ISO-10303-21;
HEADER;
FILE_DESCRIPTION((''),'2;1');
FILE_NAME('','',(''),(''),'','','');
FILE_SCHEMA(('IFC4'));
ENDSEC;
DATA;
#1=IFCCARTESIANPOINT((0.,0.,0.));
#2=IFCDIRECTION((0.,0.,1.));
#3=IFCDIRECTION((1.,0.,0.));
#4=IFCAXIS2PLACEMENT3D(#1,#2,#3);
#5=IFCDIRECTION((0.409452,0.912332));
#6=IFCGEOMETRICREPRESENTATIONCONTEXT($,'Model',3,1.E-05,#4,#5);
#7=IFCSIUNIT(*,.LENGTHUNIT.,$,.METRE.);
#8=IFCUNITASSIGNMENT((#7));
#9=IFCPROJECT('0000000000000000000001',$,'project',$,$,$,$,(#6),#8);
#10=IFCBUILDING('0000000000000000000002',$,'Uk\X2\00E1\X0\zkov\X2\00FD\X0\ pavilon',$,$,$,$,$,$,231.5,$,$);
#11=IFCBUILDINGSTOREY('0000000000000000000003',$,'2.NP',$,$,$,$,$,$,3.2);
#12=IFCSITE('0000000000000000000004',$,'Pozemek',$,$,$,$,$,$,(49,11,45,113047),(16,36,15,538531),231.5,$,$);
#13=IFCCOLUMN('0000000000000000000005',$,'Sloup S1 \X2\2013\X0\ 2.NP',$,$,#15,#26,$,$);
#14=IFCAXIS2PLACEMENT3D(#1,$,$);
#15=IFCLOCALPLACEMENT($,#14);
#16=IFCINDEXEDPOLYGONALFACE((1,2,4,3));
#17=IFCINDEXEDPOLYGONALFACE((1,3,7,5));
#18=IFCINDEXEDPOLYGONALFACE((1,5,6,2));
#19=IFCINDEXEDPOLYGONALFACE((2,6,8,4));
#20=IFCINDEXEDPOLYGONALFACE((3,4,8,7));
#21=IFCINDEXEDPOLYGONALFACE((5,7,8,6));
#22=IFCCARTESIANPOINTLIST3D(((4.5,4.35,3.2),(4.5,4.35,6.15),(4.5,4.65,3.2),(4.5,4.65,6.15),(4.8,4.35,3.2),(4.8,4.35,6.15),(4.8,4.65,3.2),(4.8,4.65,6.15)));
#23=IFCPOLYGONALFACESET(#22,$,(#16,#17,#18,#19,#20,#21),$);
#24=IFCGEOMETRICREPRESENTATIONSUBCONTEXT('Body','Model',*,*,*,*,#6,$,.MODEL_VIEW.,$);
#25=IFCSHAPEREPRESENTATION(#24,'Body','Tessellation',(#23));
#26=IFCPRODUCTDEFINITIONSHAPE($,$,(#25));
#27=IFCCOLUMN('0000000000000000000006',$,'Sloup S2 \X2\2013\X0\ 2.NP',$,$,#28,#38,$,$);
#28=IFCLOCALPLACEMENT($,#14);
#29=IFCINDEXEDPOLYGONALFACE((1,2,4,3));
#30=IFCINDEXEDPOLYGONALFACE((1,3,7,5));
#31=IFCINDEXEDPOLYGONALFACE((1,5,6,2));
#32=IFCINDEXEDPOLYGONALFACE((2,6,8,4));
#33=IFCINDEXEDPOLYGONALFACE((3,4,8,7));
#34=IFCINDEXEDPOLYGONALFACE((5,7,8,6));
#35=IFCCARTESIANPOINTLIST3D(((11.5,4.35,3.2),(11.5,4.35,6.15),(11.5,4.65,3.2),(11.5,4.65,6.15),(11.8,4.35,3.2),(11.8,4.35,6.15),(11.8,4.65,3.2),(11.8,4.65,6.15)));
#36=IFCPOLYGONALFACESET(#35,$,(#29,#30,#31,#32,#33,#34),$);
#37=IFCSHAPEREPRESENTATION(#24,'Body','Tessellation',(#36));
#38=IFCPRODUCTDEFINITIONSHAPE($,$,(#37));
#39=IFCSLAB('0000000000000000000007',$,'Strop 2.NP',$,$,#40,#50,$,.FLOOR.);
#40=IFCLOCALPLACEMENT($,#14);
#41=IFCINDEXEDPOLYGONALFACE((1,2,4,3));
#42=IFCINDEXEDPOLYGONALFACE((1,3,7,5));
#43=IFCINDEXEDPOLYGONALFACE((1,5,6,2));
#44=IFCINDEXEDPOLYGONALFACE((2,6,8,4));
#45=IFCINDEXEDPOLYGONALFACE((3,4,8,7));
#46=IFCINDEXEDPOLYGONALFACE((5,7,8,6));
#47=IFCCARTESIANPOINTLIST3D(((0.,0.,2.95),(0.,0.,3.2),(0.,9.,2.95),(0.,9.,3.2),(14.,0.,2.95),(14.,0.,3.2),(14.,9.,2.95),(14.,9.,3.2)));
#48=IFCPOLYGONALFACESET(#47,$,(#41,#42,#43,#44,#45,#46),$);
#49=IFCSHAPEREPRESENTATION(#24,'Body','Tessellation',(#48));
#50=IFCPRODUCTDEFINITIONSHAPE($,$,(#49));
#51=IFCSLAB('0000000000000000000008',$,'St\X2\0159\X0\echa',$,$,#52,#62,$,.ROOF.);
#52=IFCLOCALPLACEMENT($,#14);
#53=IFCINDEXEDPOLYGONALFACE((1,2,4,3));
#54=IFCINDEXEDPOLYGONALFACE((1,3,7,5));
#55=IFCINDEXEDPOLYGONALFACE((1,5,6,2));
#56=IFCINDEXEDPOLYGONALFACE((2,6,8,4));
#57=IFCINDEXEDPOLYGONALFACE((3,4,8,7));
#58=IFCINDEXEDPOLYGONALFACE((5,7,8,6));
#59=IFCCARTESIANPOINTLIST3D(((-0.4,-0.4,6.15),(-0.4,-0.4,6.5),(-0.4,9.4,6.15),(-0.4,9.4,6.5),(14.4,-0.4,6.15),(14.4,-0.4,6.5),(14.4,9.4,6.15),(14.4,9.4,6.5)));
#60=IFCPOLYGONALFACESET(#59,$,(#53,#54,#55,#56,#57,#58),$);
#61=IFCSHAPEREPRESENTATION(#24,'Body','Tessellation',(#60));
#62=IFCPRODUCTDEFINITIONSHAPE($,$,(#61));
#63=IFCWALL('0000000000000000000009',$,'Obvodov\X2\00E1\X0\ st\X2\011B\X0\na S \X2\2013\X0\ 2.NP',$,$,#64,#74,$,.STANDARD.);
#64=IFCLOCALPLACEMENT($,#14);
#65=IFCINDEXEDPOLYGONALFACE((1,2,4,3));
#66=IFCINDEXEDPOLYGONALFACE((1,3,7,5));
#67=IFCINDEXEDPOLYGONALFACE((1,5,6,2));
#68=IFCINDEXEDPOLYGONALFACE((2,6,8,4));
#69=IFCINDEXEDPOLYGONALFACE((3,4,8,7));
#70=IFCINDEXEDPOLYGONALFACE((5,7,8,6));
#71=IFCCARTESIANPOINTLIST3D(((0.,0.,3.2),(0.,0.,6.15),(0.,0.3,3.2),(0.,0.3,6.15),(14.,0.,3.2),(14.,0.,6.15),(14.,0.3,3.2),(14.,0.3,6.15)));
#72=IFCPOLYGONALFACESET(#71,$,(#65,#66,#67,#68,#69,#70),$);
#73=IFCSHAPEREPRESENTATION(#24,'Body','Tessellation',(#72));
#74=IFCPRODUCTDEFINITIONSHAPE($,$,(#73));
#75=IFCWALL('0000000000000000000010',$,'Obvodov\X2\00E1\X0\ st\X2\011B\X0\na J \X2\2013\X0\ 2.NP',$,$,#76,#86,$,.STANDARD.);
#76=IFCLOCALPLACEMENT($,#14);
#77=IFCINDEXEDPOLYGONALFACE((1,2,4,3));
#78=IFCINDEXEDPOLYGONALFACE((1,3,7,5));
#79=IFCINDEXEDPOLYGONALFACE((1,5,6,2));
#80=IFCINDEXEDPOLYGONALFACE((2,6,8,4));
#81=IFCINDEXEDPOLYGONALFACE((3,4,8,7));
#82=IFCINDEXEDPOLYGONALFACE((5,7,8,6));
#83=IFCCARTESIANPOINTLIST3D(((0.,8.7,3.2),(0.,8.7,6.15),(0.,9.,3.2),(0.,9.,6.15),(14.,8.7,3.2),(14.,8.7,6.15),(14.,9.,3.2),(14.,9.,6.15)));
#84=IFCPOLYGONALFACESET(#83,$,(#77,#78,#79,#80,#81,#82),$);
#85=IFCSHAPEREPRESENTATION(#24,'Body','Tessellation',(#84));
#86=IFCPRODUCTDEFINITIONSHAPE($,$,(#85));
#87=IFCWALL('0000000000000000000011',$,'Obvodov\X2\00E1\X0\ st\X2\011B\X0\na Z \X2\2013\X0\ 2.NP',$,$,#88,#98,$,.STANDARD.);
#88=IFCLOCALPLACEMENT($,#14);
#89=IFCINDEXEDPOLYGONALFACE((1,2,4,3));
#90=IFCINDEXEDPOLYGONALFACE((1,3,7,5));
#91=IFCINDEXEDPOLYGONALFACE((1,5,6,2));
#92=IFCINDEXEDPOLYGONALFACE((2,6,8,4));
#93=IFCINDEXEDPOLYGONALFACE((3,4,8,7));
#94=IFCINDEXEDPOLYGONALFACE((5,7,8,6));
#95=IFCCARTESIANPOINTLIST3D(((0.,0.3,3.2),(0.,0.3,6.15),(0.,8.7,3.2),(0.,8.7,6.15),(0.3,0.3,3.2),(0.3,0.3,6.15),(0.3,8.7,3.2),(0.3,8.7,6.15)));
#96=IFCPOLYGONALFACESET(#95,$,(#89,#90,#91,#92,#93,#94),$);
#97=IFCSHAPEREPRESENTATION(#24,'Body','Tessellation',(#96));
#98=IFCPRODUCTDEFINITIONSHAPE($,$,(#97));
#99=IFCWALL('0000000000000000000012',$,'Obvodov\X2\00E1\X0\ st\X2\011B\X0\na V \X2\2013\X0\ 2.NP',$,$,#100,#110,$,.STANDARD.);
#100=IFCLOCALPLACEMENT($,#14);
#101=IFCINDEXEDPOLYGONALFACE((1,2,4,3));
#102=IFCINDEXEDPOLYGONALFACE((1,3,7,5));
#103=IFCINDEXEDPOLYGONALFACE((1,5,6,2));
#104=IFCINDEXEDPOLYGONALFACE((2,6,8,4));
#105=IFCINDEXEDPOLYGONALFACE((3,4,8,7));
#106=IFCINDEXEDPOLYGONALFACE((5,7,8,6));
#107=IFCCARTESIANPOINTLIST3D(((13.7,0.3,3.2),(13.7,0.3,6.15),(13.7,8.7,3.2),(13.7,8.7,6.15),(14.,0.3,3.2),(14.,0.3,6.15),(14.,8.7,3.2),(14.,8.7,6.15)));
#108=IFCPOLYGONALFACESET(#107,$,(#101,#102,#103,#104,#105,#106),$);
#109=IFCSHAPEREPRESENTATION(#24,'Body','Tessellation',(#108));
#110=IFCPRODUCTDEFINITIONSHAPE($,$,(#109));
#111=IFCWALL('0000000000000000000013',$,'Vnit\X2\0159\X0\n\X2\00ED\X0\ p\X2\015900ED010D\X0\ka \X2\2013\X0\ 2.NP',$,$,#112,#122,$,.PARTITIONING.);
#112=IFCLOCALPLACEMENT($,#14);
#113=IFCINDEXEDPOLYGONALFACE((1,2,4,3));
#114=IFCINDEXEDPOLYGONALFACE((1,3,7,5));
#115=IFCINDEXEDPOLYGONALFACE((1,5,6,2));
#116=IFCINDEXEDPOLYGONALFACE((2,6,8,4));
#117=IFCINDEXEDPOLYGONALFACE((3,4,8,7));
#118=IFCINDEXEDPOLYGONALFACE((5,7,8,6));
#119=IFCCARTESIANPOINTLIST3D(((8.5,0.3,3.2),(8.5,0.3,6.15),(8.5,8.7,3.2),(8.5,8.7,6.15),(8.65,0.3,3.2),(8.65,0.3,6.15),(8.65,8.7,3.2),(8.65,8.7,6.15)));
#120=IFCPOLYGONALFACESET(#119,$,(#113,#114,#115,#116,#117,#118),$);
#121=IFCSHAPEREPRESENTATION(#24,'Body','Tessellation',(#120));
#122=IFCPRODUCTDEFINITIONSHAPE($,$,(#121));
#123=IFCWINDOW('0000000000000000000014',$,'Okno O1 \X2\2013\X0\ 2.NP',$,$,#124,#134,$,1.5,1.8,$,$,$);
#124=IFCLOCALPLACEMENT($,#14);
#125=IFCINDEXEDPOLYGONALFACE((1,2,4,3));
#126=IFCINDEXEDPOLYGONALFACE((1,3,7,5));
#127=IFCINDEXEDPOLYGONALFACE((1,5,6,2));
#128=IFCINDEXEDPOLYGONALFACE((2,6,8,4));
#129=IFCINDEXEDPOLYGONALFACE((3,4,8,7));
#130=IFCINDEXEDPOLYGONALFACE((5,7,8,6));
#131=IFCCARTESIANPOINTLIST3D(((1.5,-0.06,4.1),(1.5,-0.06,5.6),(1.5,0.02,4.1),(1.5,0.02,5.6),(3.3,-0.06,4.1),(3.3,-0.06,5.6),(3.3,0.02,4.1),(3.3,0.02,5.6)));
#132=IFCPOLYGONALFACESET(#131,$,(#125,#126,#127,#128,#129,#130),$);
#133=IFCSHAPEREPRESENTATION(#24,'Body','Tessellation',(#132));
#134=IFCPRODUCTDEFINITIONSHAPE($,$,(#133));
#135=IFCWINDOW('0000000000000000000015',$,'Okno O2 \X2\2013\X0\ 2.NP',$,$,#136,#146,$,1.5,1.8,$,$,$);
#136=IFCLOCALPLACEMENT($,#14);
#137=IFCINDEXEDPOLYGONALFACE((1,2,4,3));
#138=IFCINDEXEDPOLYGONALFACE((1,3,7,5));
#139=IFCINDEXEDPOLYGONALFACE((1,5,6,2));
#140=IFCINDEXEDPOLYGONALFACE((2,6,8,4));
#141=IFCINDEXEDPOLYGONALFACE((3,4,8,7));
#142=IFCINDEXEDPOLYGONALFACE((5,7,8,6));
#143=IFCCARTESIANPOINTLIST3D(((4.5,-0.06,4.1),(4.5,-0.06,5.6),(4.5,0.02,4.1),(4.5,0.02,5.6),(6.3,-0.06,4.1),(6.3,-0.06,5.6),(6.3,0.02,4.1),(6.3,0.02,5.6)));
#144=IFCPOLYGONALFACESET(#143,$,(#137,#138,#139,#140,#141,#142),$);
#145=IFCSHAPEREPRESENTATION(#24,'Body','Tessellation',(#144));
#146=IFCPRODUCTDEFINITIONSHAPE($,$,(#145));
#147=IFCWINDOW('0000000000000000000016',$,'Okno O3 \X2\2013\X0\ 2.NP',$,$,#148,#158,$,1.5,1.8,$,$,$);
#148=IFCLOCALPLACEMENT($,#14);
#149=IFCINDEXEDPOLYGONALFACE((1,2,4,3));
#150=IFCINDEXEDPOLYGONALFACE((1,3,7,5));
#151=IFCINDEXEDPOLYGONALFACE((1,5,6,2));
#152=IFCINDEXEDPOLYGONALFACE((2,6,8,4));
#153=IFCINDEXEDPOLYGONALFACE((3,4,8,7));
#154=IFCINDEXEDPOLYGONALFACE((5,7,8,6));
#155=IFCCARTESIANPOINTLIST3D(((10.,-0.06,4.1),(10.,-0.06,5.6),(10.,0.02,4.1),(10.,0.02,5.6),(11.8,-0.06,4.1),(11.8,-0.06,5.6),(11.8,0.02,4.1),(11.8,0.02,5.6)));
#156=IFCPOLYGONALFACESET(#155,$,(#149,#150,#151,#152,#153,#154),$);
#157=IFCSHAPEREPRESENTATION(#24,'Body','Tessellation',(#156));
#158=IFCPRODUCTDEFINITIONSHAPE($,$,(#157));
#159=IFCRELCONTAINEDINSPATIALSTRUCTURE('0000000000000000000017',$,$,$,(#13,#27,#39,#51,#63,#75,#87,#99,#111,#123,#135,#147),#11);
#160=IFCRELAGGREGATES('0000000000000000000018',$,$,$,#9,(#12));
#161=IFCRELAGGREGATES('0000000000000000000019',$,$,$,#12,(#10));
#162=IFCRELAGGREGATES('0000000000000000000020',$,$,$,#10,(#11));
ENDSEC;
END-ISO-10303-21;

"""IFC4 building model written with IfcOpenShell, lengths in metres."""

from ifc_helpers import new_model, si_unit, direction, frame, frame_2d, origin, origin_with_axes, place, context, subcontext, project, spatial, rectangle, extrude, element, save


model = new_model("IFC4")

# Units and contexts
model_context = context("Model", 3, precision=1e-05, world=origin_with_axes(), true_north=direction((0.409452, 0.912332)))
body_context = subcontext(model_context, "Body", "Model", "MODEL_VIEW")
ifc_project = project(units=[si_unit("LENGTHUNIT", "METRE")], contexts=[model_context])

# Site, building, storey
site = spatial("IfcSite", under=ifc_project, Name="Pozemek", RefLatitude=(49, 11, 45, 113047), RefLongitude=(16, 36, 15, 538531), RefElevation=231.5)
building = spatial("IfcBuilding", under=site, Name="Ukázkový pavilon", ElevationOfRefHeight=231.5)
storey = spatial("IfcBuildingStorey", under=building, Name="2.NP", Elevation=3.2)

# Columns
for number, where, z_axis, x_axis, name in (
    (1, (4.5, 4.35, 3.2), (0.0, 0.0, 1.0), (1.0, 0.0, 0.0), "Sloup S1 – 2.NP"),
    (2, (11.5, 4.35, 3.2), (0.0, 0.0, 1.0), (1.0, 0.0, 0.0), "Sloup S2 – 2.NP"),
):
    element("IfcColumn", number, at=place(None, frame(where, z_axis=z_axis, x_axis=x_axis)), inside=storey, Name=name, context=body_context, shape_type="SweptSolid", body=[
        extrude(rectangle(XDim=0.3, YDim=0.3, at=frame_2d((0.15, 0.15))), origin(), (0.0, 0.0, 1.0), 2.95),
    ])

# Slabs
slab_1_placement = place(None, frame((0.0, 0.0, 2.95), z_axis=(0.0, 0.0, 1.0), x_axis=(1.0, 0.0, 0.0)))
element("IfcSlab", 3, at=slab_1_placement, inside=storey, Name="Strop 2.NP", PredefinedType="FLOOR", context=body_context, shape_type="SweptSolid", body=[
    extrude(rectangle(XDim=14.0, YDim=9.0, at=frame_2d((7.0, 4.5))), origin(), (0.0, 0.0, 1.0), 0.25),
])
slab_2_placement = place(None, frame((-0.4, -0.4, 6.15), z_axis=(0.0, 0.0, 1.0), x_axis=(1.0, 0.0, 0.0)))
element("IfcSlab", 4, at=slab_2_placement, inside=storey, Name="Střecha", PredefinedType="ROOF", context=body_context, shape_type="SweptSolid", body=[
    extrude(rectangle(XDim=14.8, YDim=9.8, at=frame_2d((7.4, 4.9))), origin(), (0.0, 0.0, 1.0), 0.35),
])

# Walls
for number, where, z_axis, x_axis, name in (
    (5, (0.0, 0.0, 3.2), (0.0, 0.0, 1.0), (1.0, 0.0, 0.0), "Obvodová stěna S – 2.NP"),
    (6, (0.0, 8.7, 3.2), (0.0, 0.0, 1.0), (1.0, 0.0, 0.0), "Obvodová stěna J – 2.NP"),
):
    element("IfcWall", number, at=place(None, frame(where, z_axis=z_axis, x_axis=x_axis)), inside=storey, Name=name, PredefinedType="STANDARD", context=body_context, shape_type="SweptSolid", body=[
        extrude(rectangle(XDim=14.0, YDim=0.3, at=frame_2d((7.0, 0.15))), origin(), (0.0, 0.0, 1.0), 2.95),
    ])
for number, where, z_axis, x_axis, name in (
    (7, (0.0, 0.3, 3.2), (0.0, 0.0, 1.0), (1.0, 0.0, 0.0), "Obvodová stěna Z – 2.NP"),
    (8, (13.7, 0.3, 3.2), (0.0, 0.0, 1.0), (1.0, 0.0, 0.0), "Obvodová stěna V – 2.NP"),
):
    element("IfcWall", number, at=place(None, frame(where, z_axis=z_axis, x_axis=x_axis)), inside=storey, Name=name, PredefinedType="STANDARD", context=body_context, shape_type="SweptSolid", body=[
        extrude(rectangle(XDim=0.3, YDim=8.4, at=frame_2d((0.15, 4.2))), origin(), (0.0, 0.0, 1.0), 2.95),
    ])
wall_placement = place(None, frame((8.5, 0.3, 3.2), z_axis=(0.0, 0.0, 1.0), x_axis=(1.0, 0.0, 0.0)))
element("IfcWall", 9, at=wall_placement, inside=storey, Name="Vnitřní příčka – 2.NP", PredefinedType="PARTITIONING", context=body_context, shape_type="SweptSolid", body=[
    extrude(rectangle(XDim=0.15, YDim=8.4, at=frame_2d((0.075, 4.2))), origin(), (0.0, 0.0, 1.0), 2.95),
])

# Windows
for number, where, z_axis, x_axis, name in (
    (10, (1.5, -0.06, 4.1), (0.0, 0.0, 1.0), (1.0, 0.0, 0.0), "Okno O1 – 2.NP"),
    (11, (4.5, -0.06, 4.1), (0.0, 0.0, 1.0), (1.0, 0.0, 0.0), "Okno O2 – 2.NP"),
    (12, (10.0, -0.06, 4.1), (0.0, 0.0, 1.0), (1.0, 0.0, 0.0), "Okno O3 – 2.NP"),
):
    element("IfcWindow", number, at=place(None, frame(where, z_axis=z_axis, x_axis=x_axis)), inside=storey, Name=name, OverallHeight=1.5, OverallWidth=1.8, context=body_context, shape_type="SweptSolid", body=[
        extrude(rectangle(XDim=1.8, YDim=0.08, at=frame_2d((0.9, 0.04))), origin(), (0.0, 0.0, 1.0), 1.5),
    ])

save(model, "model.ifc")
